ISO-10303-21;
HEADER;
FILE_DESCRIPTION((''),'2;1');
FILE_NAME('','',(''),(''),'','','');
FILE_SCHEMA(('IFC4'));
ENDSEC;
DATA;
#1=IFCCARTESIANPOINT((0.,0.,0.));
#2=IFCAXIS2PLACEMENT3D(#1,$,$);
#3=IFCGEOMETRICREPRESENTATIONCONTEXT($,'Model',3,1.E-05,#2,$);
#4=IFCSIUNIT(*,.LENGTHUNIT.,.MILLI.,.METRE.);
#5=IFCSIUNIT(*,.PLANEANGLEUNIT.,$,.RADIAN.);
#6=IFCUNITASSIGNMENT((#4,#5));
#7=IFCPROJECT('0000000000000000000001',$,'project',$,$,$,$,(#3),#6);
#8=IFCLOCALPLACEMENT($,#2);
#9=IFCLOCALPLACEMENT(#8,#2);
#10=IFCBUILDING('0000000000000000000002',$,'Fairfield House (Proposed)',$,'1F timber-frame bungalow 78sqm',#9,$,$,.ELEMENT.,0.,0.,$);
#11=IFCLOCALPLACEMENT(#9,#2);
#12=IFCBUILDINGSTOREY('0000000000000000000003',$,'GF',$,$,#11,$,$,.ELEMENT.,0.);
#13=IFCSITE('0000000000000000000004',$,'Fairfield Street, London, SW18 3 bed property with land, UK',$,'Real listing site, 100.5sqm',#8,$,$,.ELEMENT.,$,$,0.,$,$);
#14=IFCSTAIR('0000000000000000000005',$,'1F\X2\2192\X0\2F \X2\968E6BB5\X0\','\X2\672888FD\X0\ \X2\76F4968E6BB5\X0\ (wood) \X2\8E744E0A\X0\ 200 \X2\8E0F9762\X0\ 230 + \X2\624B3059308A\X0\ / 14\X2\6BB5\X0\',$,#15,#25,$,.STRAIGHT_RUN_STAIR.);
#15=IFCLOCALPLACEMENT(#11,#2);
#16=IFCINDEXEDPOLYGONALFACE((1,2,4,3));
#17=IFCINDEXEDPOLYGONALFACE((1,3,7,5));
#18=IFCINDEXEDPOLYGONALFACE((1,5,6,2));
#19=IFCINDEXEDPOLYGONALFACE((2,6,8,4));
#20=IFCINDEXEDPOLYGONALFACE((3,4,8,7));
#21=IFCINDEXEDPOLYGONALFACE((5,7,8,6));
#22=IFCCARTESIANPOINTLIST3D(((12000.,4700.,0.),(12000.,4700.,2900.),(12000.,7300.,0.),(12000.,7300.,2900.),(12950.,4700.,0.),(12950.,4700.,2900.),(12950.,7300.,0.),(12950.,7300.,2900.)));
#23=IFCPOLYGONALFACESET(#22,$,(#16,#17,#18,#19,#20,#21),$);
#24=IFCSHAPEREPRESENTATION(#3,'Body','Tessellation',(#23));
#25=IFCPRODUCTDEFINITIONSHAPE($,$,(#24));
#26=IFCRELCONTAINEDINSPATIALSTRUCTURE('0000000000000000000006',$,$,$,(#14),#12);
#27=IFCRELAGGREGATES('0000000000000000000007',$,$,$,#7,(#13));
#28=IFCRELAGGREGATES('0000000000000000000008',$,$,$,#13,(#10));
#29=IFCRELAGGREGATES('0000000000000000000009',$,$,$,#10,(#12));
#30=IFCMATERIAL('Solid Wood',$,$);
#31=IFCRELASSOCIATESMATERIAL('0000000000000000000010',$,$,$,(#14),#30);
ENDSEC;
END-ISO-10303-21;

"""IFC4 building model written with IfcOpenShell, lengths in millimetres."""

from ifc_helpers import new_model, si_unit, frame, frame_2d, origin, place, context, project, spatial, rectangle, extrude, material, element, save


model = new_model("IFC4")

# Units and contexts
model_context = context("Model", 3, precision=1e-05, world=origin())
ifc_project = project(units=[si_unit("LENGTHUNIT", "METRE", prefix="MILLI"), si_unit("PLANEANGLEUNIT", "RADIAN")], contexts=[model_context])

# Site, building, storey
site_placement = place(None, origin())
site = spatial("IfcSite", under=ifc_project, at=site_placement, Name="Fairfield Street, London, SW18 3 bed property with land, UK", ObjectType="Real listing site, 100.5sqm", CompositionType="ELEMENT", RefElevation=0.0)
building_placement = place(site_placement, origin())
building = spatial("IfcBuilding", under=site, at=building_placement, Name="Fairfield House (Proposed)", ObjectType="1F timber-frame bungalow 78sqm", CompositionType="ELEMENT", ElevationOfRefHeight=0.0, ElevationOfTerrain=0.0)
storey_placement = place(building_placement, origin())
storey = spatial("IfcBuildingStorey", under=building, at=storey_placement, Name="GF", CompositionType="ELEMENT", Elevation=0.0)

# Shared definitions
ifc_material_1 = material(Name="Solid Wood")

# Stair
stair_placement = place(storey_placement, frame((6000.0, 2350.0, 0.0)))
element("IfcStair", 1, at=stair_placement, inside=storey, material=ifc_material_1, Name="1F→2F 階段", Description="木製 直階段 (wood) 蹴上 200 踏面 230 + 手すり / 14段", PredefinedType="STRAIGHT_RUN_STAIR", context=model_context, shape_type="SweptSolid", body=[
    extrude(rectangle(XDim=950.0, YDim=2600.0, at=frame_2d((475.0, 1300.0))), frame((6000.0, 2350.0, 0.0)), (0.0, 0.0, 1.0), 2900.0),
])

save(model, "model.ifc")
